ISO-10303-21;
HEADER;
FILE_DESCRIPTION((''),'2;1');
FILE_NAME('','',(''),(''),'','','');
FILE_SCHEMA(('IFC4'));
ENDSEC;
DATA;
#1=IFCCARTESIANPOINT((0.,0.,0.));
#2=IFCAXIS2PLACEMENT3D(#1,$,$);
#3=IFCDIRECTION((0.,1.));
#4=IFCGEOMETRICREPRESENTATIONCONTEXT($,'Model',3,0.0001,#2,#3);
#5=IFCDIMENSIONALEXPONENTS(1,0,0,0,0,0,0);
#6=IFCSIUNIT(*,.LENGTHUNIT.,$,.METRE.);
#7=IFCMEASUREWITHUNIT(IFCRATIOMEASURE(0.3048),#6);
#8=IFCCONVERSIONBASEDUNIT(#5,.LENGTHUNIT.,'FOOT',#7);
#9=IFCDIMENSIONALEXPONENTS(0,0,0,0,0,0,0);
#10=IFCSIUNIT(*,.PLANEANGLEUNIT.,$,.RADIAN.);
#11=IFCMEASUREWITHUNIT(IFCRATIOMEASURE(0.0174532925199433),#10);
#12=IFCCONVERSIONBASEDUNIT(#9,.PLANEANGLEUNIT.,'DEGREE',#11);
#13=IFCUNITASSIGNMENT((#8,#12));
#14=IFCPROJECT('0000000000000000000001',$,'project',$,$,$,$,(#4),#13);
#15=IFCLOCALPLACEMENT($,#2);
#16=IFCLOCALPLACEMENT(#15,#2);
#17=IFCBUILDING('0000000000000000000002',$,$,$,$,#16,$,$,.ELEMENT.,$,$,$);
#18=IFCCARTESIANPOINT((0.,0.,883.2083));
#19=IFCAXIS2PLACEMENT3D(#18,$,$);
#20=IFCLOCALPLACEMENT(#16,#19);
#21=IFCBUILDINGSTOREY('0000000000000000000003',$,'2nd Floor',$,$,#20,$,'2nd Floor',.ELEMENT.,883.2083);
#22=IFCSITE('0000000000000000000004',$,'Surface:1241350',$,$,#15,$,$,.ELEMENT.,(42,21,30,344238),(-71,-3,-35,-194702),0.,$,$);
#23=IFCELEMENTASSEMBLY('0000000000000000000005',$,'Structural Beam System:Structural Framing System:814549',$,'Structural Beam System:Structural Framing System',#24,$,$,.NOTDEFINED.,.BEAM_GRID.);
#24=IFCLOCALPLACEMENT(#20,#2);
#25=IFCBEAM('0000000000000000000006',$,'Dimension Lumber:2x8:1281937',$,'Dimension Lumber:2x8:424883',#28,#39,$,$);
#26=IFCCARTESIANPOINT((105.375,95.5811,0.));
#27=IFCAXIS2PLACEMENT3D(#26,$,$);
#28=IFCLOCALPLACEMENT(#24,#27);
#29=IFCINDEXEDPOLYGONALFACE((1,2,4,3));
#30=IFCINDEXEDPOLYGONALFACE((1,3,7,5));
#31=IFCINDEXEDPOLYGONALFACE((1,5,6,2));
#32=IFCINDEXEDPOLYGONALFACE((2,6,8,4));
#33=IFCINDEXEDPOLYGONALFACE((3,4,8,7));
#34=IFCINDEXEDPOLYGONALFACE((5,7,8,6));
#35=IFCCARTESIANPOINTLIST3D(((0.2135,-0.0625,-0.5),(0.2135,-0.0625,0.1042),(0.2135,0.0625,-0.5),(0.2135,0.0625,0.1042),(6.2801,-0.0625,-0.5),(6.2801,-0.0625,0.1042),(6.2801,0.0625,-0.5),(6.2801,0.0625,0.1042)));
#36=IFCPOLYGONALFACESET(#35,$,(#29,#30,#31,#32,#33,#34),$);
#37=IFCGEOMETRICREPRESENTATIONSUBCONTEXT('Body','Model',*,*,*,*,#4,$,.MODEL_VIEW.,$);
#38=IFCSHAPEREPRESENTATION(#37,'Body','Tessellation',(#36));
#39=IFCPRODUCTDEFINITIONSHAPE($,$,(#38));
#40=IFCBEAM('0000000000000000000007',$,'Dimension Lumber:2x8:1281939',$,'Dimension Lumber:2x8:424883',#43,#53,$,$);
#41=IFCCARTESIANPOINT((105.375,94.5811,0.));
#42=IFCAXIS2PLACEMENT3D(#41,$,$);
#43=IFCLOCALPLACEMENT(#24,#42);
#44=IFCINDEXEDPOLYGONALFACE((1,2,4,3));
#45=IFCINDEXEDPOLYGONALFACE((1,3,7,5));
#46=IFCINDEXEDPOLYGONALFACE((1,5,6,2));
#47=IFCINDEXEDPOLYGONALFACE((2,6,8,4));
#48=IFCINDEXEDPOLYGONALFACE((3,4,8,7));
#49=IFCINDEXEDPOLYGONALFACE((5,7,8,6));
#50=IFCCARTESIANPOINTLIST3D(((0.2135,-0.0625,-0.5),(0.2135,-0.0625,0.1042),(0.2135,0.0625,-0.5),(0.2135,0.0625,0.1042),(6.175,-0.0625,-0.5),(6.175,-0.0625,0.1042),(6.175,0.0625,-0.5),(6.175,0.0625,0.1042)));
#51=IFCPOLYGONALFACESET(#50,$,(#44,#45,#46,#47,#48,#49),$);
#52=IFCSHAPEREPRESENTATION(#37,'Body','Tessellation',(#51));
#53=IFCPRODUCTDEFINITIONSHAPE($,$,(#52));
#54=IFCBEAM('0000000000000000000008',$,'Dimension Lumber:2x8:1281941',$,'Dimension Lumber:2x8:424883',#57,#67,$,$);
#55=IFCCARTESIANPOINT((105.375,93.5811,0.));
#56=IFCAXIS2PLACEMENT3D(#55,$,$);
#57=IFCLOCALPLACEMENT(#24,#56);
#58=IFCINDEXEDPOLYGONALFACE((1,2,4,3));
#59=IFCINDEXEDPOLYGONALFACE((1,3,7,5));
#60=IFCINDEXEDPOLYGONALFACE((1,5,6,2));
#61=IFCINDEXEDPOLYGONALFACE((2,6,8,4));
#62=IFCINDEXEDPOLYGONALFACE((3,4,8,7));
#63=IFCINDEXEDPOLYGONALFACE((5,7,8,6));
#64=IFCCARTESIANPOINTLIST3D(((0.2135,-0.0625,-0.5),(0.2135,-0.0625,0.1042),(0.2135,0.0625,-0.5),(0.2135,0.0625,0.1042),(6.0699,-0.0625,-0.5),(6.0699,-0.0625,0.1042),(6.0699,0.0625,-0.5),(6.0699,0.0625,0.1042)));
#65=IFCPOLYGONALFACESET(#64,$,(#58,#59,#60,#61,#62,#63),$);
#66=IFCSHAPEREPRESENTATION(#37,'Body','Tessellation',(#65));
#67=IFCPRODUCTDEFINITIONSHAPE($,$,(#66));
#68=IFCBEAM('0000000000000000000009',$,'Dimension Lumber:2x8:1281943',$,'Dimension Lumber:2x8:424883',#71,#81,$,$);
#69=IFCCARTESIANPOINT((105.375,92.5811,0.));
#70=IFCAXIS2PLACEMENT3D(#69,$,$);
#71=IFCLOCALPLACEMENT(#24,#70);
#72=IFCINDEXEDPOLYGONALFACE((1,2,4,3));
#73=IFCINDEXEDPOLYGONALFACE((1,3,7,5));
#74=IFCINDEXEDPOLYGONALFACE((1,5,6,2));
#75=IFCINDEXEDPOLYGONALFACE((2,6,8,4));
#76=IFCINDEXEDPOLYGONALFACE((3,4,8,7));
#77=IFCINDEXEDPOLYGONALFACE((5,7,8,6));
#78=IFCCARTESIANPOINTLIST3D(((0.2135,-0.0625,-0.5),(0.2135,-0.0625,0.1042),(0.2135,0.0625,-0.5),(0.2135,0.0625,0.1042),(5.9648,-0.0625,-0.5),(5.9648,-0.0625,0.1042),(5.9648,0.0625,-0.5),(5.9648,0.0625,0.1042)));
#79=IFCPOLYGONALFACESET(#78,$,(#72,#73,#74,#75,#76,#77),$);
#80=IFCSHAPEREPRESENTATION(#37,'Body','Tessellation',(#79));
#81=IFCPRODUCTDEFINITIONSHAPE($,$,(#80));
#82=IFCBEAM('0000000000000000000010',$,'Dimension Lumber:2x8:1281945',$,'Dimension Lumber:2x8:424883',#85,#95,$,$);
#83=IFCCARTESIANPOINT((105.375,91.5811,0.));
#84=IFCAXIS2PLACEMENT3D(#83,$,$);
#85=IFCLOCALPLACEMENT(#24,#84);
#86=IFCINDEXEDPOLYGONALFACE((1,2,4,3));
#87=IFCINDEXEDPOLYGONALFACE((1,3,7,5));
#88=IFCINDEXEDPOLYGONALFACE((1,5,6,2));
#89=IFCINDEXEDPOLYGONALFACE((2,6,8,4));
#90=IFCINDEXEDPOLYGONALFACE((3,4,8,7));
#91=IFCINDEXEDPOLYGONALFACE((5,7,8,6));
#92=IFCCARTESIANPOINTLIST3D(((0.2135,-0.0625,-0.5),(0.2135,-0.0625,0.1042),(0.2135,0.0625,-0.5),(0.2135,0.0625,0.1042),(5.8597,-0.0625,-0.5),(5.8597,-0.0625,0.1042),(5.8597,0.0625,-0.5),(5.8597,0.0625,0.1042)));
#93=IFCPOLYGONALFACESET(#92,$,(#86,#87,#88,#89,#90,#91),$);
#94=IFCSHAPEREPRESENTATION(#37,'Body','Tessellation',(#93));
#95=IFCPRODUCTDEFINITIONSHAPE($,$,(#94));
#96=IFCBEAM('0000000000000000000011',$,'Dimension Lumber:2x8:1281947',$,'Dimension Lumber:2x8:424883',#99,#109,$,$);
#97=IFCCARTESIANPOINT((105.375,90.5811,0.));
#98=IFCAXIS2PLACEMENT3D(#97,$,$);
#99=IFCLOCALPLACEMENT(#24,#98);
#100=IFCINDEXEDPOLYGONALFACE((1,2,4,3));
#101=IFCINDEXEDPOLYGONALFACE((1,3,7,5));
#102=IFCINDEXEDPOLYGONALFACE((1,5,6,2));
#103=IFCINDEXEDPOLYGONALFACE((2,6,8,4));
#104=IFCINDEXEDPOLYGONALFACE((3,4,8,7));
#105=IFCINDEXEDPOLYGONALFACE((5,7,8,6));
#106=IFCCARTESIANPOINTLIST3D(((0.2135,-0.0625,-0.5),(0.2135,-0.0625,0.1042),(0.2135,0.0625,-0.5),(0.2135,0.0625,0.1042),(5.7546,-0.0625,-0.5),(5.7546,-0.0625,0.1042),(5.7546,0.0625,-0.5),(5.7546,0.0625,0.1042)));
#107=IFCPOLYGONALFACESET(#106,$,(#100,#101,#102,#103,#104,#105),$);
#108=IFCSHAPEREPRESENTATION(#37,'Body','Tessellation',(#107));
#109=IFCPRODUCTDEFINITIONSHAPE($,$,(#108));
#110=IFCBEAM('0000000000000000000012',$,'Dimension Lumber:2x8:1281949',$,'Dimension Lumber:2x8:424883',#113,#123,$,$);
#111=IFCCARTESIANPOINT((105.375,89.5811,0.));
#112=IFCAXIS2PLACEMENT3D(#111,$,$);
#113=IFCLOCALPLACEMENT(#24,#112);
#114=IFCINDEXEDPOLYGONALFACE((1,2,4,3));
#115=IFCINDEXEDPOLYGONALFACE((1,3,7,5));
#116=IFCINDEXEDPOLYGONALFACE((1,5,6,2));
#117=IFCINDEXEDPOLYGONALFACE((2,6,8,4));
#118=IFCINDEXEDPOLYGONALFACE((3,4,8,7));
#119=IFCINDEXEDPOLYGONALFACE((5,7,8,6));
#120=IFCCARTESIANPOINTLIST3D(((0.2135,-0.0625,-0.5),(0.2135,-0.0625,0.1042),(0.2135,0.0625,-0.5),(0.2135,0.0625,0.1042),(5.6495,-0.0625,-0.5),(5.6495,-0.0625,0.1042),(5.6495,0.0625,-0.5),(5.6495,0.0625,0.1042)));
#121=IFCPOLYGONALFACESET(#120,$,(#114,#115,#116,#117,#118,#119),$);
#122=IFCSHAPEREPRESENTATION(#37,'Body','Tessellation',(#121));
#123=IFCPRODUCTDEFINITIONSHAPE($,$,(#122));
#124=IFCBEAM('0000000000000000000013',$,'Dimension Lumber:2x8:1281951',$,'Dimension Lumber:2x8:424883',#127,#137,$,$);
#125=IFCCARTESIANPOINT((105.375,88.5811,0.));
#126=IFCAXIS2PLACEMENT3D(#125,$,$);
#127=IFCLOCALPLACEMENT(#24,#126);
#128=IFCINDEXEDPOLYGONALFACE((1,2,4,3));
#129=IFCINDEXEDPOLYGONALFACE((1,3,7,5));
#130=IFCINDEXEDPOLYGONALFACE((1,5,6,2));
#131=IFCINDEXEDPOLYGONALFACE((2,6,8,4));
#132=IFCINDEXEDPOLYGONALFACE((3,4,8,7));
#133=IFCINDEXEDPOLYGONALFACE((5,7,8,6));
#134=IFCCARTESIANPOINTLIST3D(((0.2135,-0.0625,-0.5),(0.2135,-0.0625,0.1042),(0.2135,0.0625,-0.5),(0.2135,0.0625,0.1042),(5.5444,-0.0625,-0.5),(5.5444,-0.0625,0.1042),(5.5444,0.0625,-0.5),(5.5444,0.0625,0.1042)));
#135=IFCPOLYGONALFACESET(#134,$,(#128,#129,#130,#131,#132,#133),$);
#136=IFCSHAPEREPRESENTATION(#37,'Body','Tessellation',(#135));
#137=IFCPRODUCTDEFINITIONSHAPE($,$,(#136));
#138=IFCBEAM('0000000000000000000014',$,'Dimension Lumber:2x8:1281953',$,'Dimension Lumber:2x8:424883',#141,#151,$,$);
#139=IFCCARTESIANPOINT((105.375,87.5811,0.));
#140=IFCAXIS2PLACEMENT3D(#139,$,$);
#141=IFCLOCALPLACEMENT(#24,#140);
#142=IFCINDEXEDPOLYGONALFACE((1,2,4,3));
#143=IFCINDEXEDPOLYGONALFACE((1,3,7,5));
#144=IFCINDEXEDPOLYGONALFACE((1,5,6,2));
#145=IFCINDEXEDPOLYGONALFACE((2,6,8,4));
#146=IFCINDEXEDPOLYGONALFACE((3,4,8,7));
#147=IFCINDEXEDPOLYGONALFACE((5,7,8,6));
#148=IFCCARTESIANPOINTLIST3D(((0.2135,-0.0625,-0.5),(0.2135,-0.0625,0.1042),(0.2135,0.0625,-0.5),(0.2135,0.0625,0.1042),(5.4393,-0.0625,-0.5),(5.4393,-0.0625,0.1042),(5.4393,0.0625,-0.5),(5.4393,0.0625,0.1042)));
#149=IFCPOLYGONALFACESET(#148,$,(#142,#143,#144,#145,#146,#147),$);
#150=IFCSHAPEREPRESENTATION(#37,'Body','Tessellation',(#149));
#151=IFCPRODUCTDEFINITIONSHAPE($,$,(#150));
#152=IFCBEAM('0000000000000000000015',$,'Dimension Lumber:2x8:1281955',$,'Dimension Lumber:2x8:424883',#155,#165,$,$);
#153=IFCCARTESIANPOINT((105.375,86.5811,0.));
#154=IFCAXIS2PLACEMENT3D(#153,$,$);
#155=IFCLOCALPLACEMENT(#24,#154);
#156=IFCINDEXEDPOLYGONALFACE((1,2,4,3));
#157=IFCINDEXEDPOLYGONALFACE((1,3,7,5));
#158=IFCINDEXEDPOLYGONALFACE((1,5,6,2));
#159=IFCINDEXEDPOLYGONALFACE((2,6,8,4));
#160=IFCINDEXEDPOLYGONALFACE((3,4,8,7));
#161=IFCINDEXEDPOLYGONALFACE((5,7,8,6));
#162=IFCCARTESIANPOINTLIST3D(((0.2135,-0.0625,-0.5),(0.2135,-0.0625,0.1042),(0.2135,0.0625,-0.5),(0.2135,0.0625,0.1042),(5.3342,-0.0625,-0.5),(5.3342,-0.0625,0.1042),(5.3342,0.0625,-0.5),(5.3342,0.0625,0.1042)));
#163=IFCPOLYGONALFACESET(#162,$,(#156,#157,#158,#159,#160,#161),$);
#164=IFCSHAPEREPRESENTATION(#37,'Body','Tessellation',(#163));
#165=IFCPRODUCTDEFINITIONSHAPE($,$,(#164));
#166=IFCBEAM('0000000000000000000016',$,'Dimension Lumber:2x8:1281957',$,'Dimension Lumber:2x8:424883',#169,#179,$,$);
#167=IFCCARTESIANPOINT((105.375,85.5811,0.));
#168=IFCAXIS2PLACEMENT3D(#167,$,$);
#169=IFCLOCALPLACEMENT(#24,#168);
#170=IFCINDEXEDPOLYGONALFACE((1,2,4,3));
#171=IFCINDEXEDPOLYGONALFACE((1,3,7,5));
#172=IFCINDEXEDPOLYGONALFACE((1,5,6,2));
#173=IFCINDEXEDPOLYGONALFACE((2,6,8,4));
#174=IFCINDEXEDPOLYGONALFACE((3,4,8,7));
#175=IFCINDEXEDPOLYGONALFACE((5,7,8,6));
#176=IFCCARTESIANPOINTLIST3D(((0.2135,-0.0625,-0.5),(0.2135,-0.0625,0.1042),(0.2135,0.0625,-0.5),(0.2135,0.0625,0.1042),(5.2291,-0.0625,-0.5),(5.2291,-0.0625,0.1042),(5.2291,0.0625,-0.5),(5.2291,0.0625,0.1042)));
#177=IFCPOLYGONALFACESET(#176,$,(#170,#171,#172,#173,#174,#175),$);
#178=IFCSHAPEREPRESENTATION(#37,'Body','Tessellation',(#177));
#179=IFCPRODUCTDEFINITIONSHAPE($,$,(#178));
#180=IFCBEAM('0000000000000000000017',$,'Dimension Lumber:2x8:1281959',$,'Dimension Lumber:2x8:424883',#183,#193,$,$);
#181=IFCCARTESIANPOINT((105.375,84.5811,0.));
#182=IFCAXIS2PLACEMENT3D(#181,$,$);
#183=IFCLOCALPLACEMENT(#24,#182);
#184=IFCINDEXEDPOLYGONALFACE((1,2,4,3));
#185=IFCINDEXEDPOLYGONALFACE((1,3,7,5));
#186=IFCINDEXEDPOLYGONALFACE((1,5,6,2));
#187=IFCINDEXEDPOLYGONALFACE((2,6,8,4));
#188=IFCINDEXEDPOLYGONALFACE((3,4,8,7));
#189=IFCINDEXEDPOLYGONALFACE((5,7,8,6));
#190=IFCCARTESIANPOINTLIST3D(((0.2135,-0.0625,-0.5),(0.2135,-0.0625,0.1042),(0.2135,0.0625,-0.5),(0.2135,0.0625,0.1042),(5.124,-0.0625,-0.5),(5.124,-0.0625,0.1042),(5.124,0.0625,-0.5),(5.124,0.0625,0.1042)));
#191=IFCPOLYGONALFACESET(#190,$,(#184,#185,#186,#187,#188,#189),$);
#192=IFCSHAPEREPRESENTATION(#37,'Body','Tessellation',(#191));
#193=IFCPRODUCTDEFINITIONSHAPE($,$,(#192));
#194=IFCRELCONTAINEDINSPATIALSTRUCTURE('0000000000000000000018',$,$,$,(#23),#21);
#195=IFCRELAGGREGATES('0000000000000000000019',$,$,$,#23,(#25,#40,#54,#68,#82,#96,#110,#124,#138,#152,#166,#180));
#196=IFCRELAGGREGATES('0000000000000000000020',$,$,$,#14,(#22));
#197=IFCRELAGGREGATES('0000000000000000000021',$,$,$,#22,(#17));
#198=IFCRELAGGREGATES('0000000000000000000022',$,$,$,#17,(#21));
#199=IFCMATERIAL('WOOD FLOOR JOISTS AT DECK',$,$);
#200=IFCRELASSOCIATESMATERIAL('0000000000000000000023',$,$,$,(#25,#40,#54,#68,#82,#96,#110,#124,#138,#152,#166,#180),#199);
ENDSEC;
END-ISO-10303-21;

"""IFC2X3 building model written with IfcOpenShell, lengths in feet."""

from ifc_helpers import new_model, entity, si_unit, converted_unit, direction, frame, origin, origin_2d_with_axis, place, context, subcontext, project, spatial, rectangle, extrude, material, element, aggregate, save


model = new_model("IFC2X3")

# Units and contexts
model_context = context("Model", 3, precision=0.0001, world=origin(), true_north=direction((0.0, 1.0)))
body_context = subcontext(model_context, "Body", "Model", "MODEL_VIEW")
ifc_project = project(units=[converted_unit("LENGTHUNIT", "FOOT", entity("IfcRatioMeasure", 0.3048), si_unit("LENGTHUNIT", "METRE"), dimensions=[1, 0, 0, 0, 0, 0, 0]), converted_unit("PLANEANGLEUNIT", "DEGREE", entity("IfcRatioMeasure", 0.0174532925199433), si_unit("PLANEANGLEUNIT", "RADIAN"), dimensions=[0, 0, 0, 0, 0, 0, 0])], contexts=[model_context])

# Site, building, storey
site_placement = place(None, origin())
site = spatial("IfcSite", under=ifc_project, at=site_placement, Name="Surface:1241350", CompositionType="ELEMENT", RefLatitude=(42, 21, 30, 344238), RefLongitude=(-71, -3, -35, -194702), RefElevation=0.0)
building_placement = place(site_placement, origin())
building = spatial("IfcBuilding", under=site, at=building_placement, CompositionType="ELEMENT")
storey_placement = place(building_placement, frame((0.0, 0.0, 883.2083)))
storey = spatial("IfcBuildingStorey", under=building, at=storey_placement, Name="2nd Floor", LongName="2nd Floor", CompositionType="ELEMENT", Elevation=883.2083)

# Element assembly, beams
assembly_1_placement = place(storey_placement, origin())
assembly_1 = element("IfcElementAssembly", 1, at=assembly_1_placement, inside=storey, Name="Structural Beam System:Structural Framing System:814549", ObjectType="Structural Beam System:Structural Framing System", AssemblyPlace="NOTDEFINED", PredefinedType="BEAM_GRID")
ifc_material_1 = material(Name="WOOD FLOOR JOISTS AT DECK")
beam_1_placement = place(assembly_1_placement, frame((105.375, 95.5811, 0.0)))
beam_1 = element("IfcBeam", 2, at=beam_1_placement, material=ifc_material_1, Name="Dimension Lumber:2x8:1281937", ObjectType="Dimension Lumber:2x8:424883", context=body_context, shape_type="SweptSolid", body=[
    extrude(rectangle(XDim=0.6042, YDim=0.125, at=origin_2d_with_axis()), frame((0.2135, 0.0, -0.1979), z_axis=(1.0, 0.0, 0.0), x_axis=(0.0, 0.0, -1.0)), (0.0, 0.0, 1.0), 6.0666),
])
beam_2_placement = place(assembly_1_placement, frame((105.375, 94.5811, 0.0)))
beam_2 = element("IfcBeam", 3, at=beam_2_placement, material=ifc_material_1, Name="Dimension Lumber:2x8:1281939", ObjectType="Dimension Lumber:2x8:424883", context=body_context, shape_type="SweptSolid", body=[
    extrude(rectangle(XDim=0.6042, YDim=0.125, at=origin_2d_with_axis()), frame((0.2135, 0.0, -0.1979), z_axis=(1.0, 0.0, 0.0), x_axis=(0.0, 0.0, -1.0)), (0.0, 0.0, 1.0), 5.9615),
])
beam_3_placement = place(assembly_1_placement, frame((105.375, 93.5811, 0.0)))
beam_3 = element("IfcBeam", 4, at=beam_3_placement, material=ifc_material_1, Name="Dimension Lumber:2x8:1281941", ObjectType="Dimension Lumber:2x8:424883", context=body_context, shape_type="SweptSolid", body=[
    extrude(rectangle(XDim=0.6042, YDim=0.125, at=origin_2d_with_axis()), frame((0.2135, 0.0, -0.1979), z_axis=(1.0, 0.0, 0.0), x_axis=(0.0, 0.0, -1.0)), (0.0, 0.0, 1.0), 5.8564),
])
beam_4_placement = place(assembly_1_placement, frame((105.375, 92.5811, 0.0)))
beam_4 = element("IfcBeam", 5, at=beam_4_placement, material=ifc_material_1, Name="Dimension Lumber:2x8:1281943", ObjectType="Dimension Lumber:2x8:424883", context=body_context, shape_type="SweptSolid", body=[
    extrude(rectangle(XDim=0.6042, YDim=0.125, at=origin_2d_with_axis()), frame((0.2135, 0.0, -0.1979), z_axis=(1.0, 0.0, 0.0), x_axis=(0.0, 0.0, -1.0)), (0.0, 0.0, 1.0), 5.7513),
])
beam_5_placement = place(assembly_1_placement, frame((105.375, 91.5811, 0.0)))
beam_5 = element("IfcBeam", 6, at=beam_5_placement, material=ifc_material_1, Name="Dimension Lumber:2x8:1281945", ObjectType="Dimension Lumber:2x8:424883", context=body_context, shape_type="SweptSolid", body=[
    extrude(rectangle(XDim=0.6042, YDim=0.125, at=origin_2d_with_axis()), frame((0.2135, 0.0, -0.1979), z_axis=(1.0, 0.0, 0.0), x_axis=(0.0, 0.0, -1.0)), (0.0, 0.0, 1.0), 5.6462),
])
beam_6_placement = place(assembly_1_placement, frame((105.375, 90.5811, 0.0)))
beam_6 = element("IfcBeam", 7, at=beam_6_placement, material=ifc_material_1, Name="Dimension Lumber:2x8:1281947", ObjectType="Dimension Lumber:2x8:424883", context=body_context, shape_type="SweptSolid", body=[
    extrude(rectangle(XDim=0.6042, YDim=0.125, at=origin_2d_with_axis()), frame((0.2135, 0.0, -0.1979), z_axis=(1.0, 0.0, 0.0), x_axis=(0.0, 0.0, -1.0)), (0.0, 0.0, 1.0), 5.5411),
])
beam_7_placement = place(assembly_1_placement, frame((105.375, 89.5811, 0.0)))
beam_7 = element("IfcBeam", 8, at=beam_7_placement, material=ifc_material_1, Name="Dimension Lumber:2x8:1281949", ObjectType="Dimension Lumber:2x8:424883", context=body_context, shape_type="SweptSolid", body=[
    extrude(rectangle(XDim=0.6042, YDim=0.125, at=origin_2d_with_axis()), frame((0.2135, 0.0, -0.1979), z_axis=(1.0, 0.0, 0.0), x_axis=(0.0, 0.0, -1.0)), (0.0, 0.0, 1.0), 5.436),
])
beam_8_placement = place(assembly_1_placement, frame((105.375, 88.5811, 0.0)))
beam_8 = element("IfcBeam", 9, at=beam_8_placement, material=ifc_material_1, Name="Dimension Lumber:2x8:1281951", ObjectType="Dimension Lumber:2x8:424883", context=body_context, shape_type="SweptSolid", body=[
    extrude(rectangle(XDim=0.6042, YDim=0.125, at=origin_2d_with_axis()), frame((0.2135, 0.0, -0.1979), z_axis=(1.0, 0.0, 0.0), x_axis=(0.0, 0.0, -1.0)), (0.0, 0.0, 1.0), 5.3309),
])
beam_9_placement = place(assembly_1_placement, frame((105.375, 87.5811, 0.0)))
beam_9 = element("IfcBeam", 10, at=beam_9_placement, material=ifc_material_1, Name="Dimension Lumber:2x8:1281953", ObjectType="Dimension Lumber:2x8:424883", context=body_context, shape_type="SweptSolid", body=[
    extrude(rectangle(XDim=0.6042, YDim=0.125, at=origin_2d_with_axis()), frame((0.2135, 0.0, -0.1979), z_axis=(1.0, 0.0, 0.0), x_axis=(0.0, 0.0, -1.0)), (0.0, 0.0, 1.0), 5.2258),
])
beam_10_placement = place(assembly_1_placement, frame((105.375, 86.5811, 0.0)))
beam_10 = element("IfcBeam", 11, at=beam_10_placement, material=ifc_material_1, Name="Dimension Lumber:2x8:1281955", ObjectType="Dimension Lumber:2x8:424883", context=body_context, shape_type="SweptSolid", body=[
    extrude(rectangle(XDim=0.6042, YDim=0.125, at=origin_2d_with_axis()), frame((0.2135, 0.0, -0.1979), z_axis=(1.0, 0.0, 0.0), x_axis=(0.0, 0.0, -1.0)), (0.0, 0.0, 1.0), 5.1207),
])
beam_11_placement = place(assembly_1_placement, frame((105.375, 85.5811, 0.0)))
beam_11 = element("IfcBeam", 12, at=beam_11_placement, material=ifc_material_1, Name="Dimension Lumber:2x8:1281957", ObjectType="Dimension Lumber:2x8:424883", context=body_context, shape_type="SweptSolid", body=[
    extrude(rectangle(XDim=0.6042, YDim=0.125, at=origin_2d_with_axis()), frame((0.2135, 0.0, -0.1979), z_axis=(1.0, 0.0, 0.0), x_axis=(0.0, 0.0, -1.0)), (0.0, 0.0, 1.0), 5.0156),
])
beam_12_placement = place(assembly_1_placement, frame((105.375, 84.5811, 0.0)))
beam_12 = element("IfcBeam", 13, at=beam_12_placement, material=ifc_material_1, Name="Dimension Lumber:2x8:1281959", ObjectType="Dimension Lumber:2x8:424883", context=body_context, shape_type="SweptSolid", body=[
    extrude(rectangle(XDim=0.6042, YDim=0.125, at=origin_2d_with_axis()), frame((0.2135, 0.0, -0.1979), z_axis=(1.0, 0.0, 0.0), x_axis=(0.0, 0.0, -1.0)), (0.0, 0.0, 1.0), 4.9105),
])
aggregate(assembly_1, [beam_1, beam_2, beam_3, beam_4, beam_5, beam_6, beam_7, beam_8, beam_9, beam_10, beam_11, beam_12])

save(model, "model.ifc")
